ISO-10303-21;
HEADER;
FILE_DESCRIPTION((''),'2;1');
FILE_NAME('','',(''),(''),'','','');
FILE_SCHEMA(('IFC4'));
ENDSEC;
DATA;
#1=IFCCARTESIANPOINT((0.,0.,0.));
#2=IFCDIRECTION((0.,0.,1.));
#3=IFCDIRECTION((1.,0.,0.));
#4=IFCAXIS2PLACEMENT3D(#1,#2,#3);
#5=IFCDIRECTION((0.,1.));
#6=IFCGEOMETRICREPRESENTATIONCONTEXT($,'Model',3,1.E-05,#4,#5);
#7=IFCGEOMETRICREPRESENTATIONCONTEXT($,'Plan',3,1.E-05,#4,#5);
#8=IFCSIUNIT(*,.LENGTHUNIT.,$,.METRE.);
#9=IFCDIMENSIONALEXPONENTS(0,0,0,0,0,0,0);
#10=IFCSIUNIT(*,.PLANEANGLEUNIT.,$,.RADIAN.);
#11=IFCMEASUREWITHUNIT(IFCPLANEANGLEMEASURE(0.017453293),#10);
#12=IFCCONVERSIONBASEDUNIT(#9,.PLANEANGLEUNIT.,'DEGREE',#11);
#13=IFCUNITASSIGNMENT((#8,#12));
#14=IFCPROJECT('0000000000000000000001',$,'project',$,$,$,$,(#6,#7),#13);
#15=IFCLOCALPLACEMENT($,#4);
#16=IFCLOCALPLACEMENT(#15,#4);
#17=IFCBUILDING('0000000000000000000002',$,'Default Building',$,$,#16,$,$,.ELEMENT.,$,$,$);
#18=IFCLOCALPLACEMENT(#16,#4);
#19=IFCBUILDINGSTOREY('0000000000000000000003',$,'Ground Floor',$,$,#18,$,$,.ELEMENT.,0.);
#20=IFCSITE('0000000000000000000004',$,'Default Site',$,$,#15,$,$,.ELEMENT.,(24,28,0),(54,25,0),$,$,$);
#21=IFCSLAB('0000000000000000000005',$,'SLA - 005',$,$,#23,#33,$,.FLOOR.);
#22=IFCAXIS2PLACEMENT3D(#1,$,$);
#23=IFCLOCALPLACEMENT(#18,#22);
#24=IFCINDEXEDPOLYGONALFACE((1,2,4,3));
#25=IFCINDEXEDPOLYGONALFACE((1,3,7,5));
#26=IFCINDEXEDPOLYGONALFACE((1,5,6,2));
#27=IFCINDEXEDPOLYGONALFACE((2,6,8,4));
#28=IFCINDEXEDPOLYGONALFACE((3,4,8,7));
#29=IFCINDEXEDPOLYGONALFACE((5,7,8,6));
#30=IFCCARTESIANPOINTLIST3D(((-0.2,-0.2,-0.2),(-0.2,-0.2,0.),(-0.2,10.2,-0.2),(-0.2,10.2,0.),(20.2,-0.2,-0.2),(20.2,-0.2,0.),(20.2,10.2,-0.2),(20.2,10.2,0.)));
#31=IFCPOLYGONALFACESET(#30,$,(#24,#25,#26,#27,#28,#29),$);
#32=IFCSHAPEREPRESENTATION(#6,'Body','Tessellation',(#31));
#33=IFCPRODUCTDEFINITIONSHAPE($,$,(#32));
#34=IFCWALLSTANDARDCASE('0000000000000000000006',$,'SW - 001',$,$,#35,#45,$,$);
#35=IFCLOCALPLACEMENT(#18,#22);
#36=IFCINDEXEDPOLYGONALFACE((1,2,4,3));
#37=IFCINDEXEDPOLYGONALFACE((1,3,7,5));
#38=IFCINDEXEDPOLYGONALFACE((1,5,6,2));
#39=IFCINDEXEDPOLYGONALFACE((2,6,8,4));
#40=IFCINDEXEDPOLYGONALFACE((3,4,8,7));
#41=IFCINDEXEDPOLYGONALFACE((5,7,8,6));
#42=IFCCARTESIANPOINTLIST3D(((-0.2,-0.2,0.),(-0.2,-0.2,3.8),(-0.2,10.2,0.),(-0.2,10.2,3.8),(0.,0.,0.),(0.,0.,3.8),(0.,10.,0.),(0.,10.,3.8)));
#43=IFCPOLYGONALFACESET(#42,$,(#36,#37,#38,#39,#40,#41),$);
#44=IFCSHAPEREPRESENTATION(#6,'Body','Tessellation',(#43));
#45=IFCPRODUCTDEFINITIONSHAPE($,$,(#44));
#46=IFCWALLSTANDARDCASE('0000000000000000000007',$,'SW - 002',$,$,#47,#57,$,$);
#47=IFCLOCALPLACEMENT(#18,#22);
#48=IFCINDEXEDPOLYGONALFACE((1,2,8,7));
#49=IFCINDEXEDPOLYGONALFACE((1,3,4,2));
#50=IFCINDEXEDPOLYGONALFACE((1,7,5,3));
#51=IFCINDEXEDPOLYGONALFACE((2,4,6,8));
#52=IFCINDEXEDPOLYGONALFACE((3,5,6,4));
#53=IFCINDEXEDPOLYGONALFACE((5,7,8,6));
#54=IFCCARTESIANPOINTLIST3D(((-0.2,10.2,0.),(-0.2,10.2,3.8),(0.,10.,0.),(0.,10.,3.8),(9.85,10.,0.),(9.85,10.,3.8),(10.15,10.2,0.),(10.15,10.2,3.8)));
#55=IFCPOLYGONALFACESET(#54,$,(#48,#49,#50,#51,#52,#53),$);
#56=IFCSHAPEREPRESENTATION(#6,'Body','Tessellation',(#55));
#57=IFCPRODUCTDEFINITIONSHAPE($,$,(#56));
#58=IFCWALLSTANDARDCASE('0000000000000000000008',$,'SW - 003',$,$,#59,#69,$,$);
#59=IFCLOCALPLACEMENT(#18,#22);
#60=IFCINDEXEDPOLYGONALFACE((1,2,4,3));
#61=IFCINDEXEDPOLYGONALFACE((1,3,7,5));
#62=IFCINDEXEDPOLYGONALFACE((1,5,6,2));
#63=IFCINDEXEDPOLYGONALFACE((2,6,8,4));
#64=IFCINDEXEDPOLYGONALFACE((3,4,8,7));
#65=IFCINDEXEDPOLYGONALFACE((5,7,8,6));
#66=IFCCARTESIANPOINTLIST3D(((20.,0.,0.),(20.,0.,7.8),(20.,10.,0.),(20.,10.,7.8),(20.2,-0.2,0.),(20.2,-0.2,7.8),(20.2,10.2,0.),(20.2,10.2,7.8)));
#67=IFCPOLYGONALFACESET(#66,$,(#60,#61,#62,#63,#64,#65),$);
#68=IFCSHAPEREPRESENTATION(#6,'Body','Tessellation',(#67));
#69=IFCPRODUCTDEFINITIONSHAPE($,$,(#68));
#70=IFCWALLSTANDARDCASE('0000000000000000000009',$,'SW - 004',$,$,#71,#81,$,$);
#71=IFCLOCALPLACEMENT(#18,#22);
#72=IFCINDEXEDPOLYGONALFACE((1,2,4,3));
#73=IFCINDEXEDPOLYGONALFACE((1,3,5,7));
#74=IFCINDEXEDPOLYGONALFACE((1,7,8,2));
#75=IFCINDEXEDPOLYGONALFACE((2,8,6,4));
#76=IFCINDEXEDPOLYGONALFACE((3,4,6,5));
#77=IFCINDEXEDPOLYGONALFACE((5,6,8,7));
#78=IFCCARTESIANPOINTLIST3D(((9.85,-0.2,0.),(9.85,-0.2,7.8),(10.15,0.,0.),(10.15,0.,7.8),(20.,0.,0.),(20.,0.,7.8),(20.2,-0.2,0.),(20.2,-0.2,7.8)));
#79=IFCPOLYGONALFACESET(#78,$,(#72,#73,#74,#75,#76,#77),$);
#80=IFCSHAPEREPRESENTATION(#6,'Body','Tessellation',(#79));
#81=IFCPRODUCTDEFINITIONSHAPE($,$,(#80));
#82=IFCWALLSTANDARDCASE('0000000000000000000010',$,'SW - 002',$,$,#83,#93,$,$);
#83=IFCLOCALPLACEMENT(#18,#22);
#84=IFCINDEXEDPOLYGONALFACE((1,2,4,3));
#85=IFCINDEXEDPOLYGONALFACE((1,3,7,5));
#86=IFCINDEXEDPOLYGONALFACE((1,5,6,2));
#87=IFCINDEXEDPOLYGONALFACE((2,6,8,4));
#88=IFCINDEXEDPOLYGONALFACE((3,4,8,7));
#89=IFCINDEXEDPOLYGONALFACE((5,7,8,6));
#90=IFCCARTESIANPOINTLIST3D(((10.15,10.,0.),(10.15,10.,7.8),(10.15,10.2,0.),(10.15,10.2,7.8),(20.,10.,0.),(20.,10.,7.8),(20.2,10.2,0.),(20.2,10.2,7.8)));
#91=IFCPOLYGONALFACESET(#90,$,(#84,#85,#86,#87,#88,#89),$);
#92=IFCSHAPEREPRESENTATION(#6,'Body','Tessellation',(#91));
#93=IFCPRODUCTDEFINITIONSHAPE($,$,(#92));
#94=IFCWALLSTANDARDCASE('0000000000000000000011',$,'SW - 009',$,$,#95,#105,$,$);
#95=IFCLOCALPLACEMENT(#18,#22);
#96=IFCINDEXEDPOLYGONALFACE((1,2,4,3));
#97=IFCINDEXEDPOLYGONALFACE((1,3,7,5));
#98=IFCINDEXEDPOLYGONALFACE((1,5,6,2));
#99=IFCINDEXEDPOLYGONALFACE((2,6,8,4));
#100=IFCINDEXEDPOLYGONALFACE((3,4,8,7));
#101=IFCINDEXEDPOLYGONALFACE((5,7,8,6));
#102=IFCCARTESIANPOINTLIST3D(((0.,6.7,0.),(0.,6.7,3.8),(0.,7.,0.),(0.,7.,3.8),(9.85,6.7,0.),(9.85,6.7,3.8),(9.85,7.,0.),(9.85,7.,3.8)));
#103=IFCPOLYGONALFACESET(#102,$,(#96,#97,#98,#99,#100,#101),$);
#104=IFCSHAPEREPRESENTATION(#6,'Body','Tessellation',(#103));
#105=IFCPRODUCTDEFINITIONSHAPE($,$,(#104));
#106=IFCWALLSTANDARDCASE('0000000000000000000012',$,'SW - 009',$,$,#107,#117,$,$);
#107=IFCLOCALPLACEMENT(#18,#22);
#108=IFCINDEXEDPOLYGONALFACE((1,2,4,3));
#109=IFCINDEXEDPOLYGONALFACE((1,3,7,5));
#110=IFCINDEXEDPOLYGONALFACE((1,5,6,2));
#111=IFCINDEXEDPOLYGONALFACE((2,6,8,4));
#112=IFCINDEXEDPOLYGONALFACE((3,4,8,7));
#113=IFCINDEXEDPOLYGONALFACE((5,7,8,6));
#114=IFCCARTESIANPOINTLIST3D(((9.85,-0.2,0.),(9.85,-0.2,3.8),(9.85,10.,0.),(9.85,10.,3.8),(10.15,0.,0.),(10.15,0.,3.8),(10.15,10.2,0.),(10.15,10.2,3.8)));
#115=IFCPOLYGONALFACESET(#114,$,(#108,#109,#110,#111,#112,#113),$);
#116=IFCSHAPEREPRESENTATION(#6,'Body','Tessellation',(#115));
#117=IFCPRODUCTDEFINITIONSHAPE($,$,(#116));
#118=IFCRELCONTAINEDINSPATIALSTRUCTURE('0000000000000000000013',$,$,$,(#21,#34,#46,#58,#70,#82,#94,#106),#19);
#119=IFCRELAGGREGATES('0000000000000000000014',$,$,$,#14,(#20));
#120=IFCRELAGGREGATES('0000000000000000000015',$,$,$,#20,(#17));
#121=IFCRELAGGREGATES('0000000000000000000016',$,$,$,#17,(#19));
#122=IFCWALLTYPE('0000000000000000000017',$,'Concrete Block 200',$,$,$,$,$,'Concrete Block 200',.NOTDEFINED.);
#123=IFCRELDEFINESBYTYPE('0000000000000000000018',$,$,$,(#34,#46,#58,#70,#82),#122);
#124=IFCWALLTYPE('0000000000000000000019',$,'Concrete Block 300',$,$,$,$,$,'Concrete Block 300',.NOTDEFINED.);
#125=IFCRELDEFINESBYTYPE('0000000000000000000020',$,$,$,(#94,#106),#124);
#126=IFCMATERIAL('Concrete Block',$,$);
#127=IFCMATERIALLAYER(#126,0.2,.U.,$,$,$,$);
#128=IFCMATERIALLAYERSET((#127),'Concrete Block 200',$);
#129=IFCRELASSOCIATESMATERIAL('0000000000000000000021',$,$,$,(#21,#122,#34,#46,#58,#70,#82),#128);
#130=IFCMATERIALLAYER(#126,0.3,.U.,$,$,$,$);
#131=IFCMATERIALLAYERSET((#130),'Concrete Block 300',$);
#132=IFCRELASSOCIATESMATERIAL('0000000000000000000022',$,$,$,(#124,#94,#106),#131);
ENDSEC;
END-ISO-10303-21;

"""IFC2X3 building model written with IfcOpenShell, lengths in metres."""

from ifc_helpers import new_model, entity, si_unit, converted_unit, direction, frame, origin_with_axes, place, context, project, spatial, polyline, outline, extrude, material, layer, layer_set, layer_usage, type_object, element, save


model = new_model("IFC2X3")

# Units and contexts
model_context = context("Model", 3, precision=1e-05, world=origin_with_axes(), true_north=direction((0.0, 1.0)))
plan_context = context("Plan", 3, precision=1e-05, world=origin_with_axes(), true_north=direction((0.0, 1.0)))
ifc_project = project(units=[si_unit("LENGTHUNIT", "METRE"), converted_unit("PLANEANGLEUNIT", "DEGREE", entity("IfcPlaneAngleMeasure", 0.017453293), si_unit("PLANEANGLEUNIT", "RADIAN"), dimensions=[0, 0, 0, 0, 0, 0, 0])], contexts=[model_context, plan_context])

# Site, building, storey
site_placement = place(None, origin_with_axes())
site = spatial("IfcSite", under=ifc_project, at=site_placement, Name="Default Site", CompositionType="ELEMENT", RefLatitude=(24, 28, 0), RefLongitude=(54, 25, 0))
building_placement = place(site_placement, origin_with_axes())
building = spatial("IfcBuilding", under=site, at=building_placement, Name="Default Building", CompositionType="ELEMENT")
storey_placement = place(building_placement, origin_with_axes())
storey = spatial("IfcBuildingStorey", under=building, at=storey_placement, Name="Ground Floor", CompositionType="ELEMENT", Elevation=0.0)

# Slab
ifc_material = material(Name="Concrete Block")
ifc_layer_1 = layer(ifc_material, 0.2, ventilated="UNKNOWN")
ifc_layer_set_1 = layer_set([ifc_layer_1], Name="Concrete Block 200")
ifc_layer_usage_1 = layer_usage(ifc_layer_set_1, "AXIS3", "NEGATIVE", 0.2)
slab_placement = place(storey_placement, frame((-0.2, 10.2, -0.2), z_axis=(0.0, 0.0, 1.0), x_axis=(1.0, 0.0, 0.0)))
element("IfcSlab", 1, at=slab_placement, inside=storey, material=ifc_layer_usage_1, Name="SLA - 005", PredefinedType="FLOOR", context=model_context, shape_type="SweptSolid", body=[
    extrude(outline(polyline([(0.0, 0.0), (20.4, 0.0), (20.4, -10.4), (0.0, -10.4), (0.0, 0.0)])), origin_with_axes(), (0.0, 0.0, 1.0), 0.2),
])

# Walls
ifc_layer_usage_2 = layer_usage(ifc_layer_set_1, "AXIS2", "POSITIVE", 0.0)
wall_type_1 = type_object("IfcWallType", Name="Concrete Block 200", ElementType="Concrete Block 200", PredefinedType="NOTDEFINED", material=ifc_layer_set_1)
wall_1_placement = place(storey_placement, frame((0.0, 0.0, 0.0), z_axis=(0.0, 0.0, 1.0), x_axis=(0.0, 1.0, 0.0)))
element("IfcWallStandardCase", 2, at=wall_1_placement, inside=storey, type_object=wall_type_1, material=ifc_layer_usage_2, Name="SW - 001", context=model_context, shape_type="SweptSolid", body=[
    extrude(outline(polyline([(0.0, 0.0), (10.0, 0.0), (10.2, 0.2), (-0.2, 0.2), (0.0, 0.0)])), origin_with_axes(), (0.0, 0.0, 1.0), 3.8),
])
ifc_layer_usage_3 = layer_usage(ifc_layer_set_1, "AXIS2", "POSITIVE", 0.0)
wall_2_placement = place(storey_placement, frame((0.0, 10.0, 0.0), z_axis=(0.0, 0.0, 1.0), x_axis=(1.0, 0.0, 0.0)))
element("IfcWallStandardCase", 3, at=wall_2_placement, inside=storey, type_object=wall_type_1, material=ifc_layer_usage_3, Name="SW - 002", context=model_context, shape_type="SweptSolid", body=[
    extrude(outline(polyline([(0.0, 0.0), (9.85, 0.0), (10.15, 0.2), (-0.2, 0.2), (0.0, 0.0)])), origin_with_axes(), (0.0, 0.0, 1.0), 3.8),
])
ifc_layer_usage_4 = layer_usage(ifc_layer_set_1, "AXIS2", "POSITIVE", 0.0)
wall_3_placement = place(storey_placement, frame((20.0, 10.0, 0.0), z_axis=(0.0, 0.0, 1.0), x_axis=(0.0, -1.0, 0.0)))
element("IfcWallStandardCase", 4, at=wall_3_placement, inside=storey, type_object=wall_type_1, material=ifc_layer_usage_4, Name="SW - 003", context=model_context, shape_type="SweptSolid", body=[
    extrude(outline(polyline([(0.0, 0.0), (10.0, 0.0), (10.2, 0.2), (-0.2, 0.2), (0.0, 0.0)])), origin_with_axes(), (0.0, 0.0, 1.0), 7.8),
])
ifc_layer_usage_5 = layer_usage(ifc_layer_set_1, "AXIS2", "POSITIVE", 0.0)
wall_4_placement = place(storey_placement, frame((20.0, 0.0, 0.0), z_axis=(0.0, 0.0, 1.0), x_axis=(-1.0, 0.0, 0.0)))
element("IfcWallStandardCase", 5, at=wall_4_placement, inside=storey, type_object=wall_type_1, material=ifc_layer_usage_5, Name="SW - 004", context=model_context, shape_type="SweptSolid", body=[
    extrude(outline(polyline([(0.0, 0.0), (9.85, 0.0), (10.15, 0.2), (-0.2, 0.2), (0.0, 0.0)])), origin_with_axes(), (0.0, 0.0, 1.0), 7.8),
])
ifc_layer_usage_6 = layer_usage(ifc_layer_set_1, "AXIS2", "POSITIVE", 0.0)
wall_5_placement = place(storey_placement, frame((10.15, 10.0, 0.0), z_axis=(0.0, 0.0, 1.0), x_axis=(1.0, 0.0, 0.0)))
element("IfcWallStandardCase", 6, at=wall_5_placement, inside=storey, type_object=wall_type_1, material=ifc_layer_usage_6, Name="SW - 002", context=model_context, shape_type="SweptSolid", body=[
    extrude(outline(polyline([(0.0, 0.0), (9.85, 0.0), (10.05, 0.2), (0.0, 0.2), (0.0, 0.0)])), origin_with_axes(), (0.0, 0.0, 1.0), 7.8),
])
ifc_layer_2 = layer(ifc_material, 0.3, ventilated="UNKNOWN")
ifc_layer_set_2 = layer_set([ifc_layer_2], Name="Concrete Block 300")
ifc_layer_usage_7 = layer_usage(ifc_layer_set_2, "AXIS2", "NEGATIVE", 0.15)
wall_type_2 = type_object("IfcWallType", Name="Concrete Block 300", ElementType="Concrete Block 300", PredefinedType="NOTDEFINED", material=ifc_layer_set_2)
wall_6_placement = place(storey_placement, frame((10.15, 6.85, 0.0), z_axis=(0.0, 0.0, 1.0), x_axis=(-1.0, 0.0, 0.0)))
element("IfcWallStandardCase", 7, at=wall_6_placement, inside=storey, type_object=wall_type_2, material=ifc_layer_usage_7, Name="SW - 009", context=model_context, shape_type="SweptSolid", body=[
    extrude(outline(polyline([(0.3, -0.15), (10.15, -0.15), (10.15, 0.15), (0.3, 0.15), (0.3, -0.15)])), origin_with_axes(), (0.0, 0.0, 1.0), 3.8),
])
ifc_layer_usage_8 = layer_usage(ifc_layer_set_2, "AXIS2", "POSITIVE", 0.0)
wall_7_placement = place(storey_placement, frame((10.15, 0.0, 0.0), z_axis=(0.0, 0.0, 1.0), x_axis=(0.0, 1.0, 0.0)))
element("IfcWallStandardCase", 8, at=wall_7_placement, inside=storey, type_object=wall_type_2, material=ifc_layer_usage_8, Name="SW - 009", context=model_context, shape_type="SweptSolid", body=[
    extrude(outline(polyline([(0.0, 0.0), (10.2, 0.0), (10.0, 0.3), (-0.2, 0.3), (0.0, 0.0)])), origin_with_axes(), (0.0, 0.0, 1.0), 3.8),
])

save(model, "model.ifc")
